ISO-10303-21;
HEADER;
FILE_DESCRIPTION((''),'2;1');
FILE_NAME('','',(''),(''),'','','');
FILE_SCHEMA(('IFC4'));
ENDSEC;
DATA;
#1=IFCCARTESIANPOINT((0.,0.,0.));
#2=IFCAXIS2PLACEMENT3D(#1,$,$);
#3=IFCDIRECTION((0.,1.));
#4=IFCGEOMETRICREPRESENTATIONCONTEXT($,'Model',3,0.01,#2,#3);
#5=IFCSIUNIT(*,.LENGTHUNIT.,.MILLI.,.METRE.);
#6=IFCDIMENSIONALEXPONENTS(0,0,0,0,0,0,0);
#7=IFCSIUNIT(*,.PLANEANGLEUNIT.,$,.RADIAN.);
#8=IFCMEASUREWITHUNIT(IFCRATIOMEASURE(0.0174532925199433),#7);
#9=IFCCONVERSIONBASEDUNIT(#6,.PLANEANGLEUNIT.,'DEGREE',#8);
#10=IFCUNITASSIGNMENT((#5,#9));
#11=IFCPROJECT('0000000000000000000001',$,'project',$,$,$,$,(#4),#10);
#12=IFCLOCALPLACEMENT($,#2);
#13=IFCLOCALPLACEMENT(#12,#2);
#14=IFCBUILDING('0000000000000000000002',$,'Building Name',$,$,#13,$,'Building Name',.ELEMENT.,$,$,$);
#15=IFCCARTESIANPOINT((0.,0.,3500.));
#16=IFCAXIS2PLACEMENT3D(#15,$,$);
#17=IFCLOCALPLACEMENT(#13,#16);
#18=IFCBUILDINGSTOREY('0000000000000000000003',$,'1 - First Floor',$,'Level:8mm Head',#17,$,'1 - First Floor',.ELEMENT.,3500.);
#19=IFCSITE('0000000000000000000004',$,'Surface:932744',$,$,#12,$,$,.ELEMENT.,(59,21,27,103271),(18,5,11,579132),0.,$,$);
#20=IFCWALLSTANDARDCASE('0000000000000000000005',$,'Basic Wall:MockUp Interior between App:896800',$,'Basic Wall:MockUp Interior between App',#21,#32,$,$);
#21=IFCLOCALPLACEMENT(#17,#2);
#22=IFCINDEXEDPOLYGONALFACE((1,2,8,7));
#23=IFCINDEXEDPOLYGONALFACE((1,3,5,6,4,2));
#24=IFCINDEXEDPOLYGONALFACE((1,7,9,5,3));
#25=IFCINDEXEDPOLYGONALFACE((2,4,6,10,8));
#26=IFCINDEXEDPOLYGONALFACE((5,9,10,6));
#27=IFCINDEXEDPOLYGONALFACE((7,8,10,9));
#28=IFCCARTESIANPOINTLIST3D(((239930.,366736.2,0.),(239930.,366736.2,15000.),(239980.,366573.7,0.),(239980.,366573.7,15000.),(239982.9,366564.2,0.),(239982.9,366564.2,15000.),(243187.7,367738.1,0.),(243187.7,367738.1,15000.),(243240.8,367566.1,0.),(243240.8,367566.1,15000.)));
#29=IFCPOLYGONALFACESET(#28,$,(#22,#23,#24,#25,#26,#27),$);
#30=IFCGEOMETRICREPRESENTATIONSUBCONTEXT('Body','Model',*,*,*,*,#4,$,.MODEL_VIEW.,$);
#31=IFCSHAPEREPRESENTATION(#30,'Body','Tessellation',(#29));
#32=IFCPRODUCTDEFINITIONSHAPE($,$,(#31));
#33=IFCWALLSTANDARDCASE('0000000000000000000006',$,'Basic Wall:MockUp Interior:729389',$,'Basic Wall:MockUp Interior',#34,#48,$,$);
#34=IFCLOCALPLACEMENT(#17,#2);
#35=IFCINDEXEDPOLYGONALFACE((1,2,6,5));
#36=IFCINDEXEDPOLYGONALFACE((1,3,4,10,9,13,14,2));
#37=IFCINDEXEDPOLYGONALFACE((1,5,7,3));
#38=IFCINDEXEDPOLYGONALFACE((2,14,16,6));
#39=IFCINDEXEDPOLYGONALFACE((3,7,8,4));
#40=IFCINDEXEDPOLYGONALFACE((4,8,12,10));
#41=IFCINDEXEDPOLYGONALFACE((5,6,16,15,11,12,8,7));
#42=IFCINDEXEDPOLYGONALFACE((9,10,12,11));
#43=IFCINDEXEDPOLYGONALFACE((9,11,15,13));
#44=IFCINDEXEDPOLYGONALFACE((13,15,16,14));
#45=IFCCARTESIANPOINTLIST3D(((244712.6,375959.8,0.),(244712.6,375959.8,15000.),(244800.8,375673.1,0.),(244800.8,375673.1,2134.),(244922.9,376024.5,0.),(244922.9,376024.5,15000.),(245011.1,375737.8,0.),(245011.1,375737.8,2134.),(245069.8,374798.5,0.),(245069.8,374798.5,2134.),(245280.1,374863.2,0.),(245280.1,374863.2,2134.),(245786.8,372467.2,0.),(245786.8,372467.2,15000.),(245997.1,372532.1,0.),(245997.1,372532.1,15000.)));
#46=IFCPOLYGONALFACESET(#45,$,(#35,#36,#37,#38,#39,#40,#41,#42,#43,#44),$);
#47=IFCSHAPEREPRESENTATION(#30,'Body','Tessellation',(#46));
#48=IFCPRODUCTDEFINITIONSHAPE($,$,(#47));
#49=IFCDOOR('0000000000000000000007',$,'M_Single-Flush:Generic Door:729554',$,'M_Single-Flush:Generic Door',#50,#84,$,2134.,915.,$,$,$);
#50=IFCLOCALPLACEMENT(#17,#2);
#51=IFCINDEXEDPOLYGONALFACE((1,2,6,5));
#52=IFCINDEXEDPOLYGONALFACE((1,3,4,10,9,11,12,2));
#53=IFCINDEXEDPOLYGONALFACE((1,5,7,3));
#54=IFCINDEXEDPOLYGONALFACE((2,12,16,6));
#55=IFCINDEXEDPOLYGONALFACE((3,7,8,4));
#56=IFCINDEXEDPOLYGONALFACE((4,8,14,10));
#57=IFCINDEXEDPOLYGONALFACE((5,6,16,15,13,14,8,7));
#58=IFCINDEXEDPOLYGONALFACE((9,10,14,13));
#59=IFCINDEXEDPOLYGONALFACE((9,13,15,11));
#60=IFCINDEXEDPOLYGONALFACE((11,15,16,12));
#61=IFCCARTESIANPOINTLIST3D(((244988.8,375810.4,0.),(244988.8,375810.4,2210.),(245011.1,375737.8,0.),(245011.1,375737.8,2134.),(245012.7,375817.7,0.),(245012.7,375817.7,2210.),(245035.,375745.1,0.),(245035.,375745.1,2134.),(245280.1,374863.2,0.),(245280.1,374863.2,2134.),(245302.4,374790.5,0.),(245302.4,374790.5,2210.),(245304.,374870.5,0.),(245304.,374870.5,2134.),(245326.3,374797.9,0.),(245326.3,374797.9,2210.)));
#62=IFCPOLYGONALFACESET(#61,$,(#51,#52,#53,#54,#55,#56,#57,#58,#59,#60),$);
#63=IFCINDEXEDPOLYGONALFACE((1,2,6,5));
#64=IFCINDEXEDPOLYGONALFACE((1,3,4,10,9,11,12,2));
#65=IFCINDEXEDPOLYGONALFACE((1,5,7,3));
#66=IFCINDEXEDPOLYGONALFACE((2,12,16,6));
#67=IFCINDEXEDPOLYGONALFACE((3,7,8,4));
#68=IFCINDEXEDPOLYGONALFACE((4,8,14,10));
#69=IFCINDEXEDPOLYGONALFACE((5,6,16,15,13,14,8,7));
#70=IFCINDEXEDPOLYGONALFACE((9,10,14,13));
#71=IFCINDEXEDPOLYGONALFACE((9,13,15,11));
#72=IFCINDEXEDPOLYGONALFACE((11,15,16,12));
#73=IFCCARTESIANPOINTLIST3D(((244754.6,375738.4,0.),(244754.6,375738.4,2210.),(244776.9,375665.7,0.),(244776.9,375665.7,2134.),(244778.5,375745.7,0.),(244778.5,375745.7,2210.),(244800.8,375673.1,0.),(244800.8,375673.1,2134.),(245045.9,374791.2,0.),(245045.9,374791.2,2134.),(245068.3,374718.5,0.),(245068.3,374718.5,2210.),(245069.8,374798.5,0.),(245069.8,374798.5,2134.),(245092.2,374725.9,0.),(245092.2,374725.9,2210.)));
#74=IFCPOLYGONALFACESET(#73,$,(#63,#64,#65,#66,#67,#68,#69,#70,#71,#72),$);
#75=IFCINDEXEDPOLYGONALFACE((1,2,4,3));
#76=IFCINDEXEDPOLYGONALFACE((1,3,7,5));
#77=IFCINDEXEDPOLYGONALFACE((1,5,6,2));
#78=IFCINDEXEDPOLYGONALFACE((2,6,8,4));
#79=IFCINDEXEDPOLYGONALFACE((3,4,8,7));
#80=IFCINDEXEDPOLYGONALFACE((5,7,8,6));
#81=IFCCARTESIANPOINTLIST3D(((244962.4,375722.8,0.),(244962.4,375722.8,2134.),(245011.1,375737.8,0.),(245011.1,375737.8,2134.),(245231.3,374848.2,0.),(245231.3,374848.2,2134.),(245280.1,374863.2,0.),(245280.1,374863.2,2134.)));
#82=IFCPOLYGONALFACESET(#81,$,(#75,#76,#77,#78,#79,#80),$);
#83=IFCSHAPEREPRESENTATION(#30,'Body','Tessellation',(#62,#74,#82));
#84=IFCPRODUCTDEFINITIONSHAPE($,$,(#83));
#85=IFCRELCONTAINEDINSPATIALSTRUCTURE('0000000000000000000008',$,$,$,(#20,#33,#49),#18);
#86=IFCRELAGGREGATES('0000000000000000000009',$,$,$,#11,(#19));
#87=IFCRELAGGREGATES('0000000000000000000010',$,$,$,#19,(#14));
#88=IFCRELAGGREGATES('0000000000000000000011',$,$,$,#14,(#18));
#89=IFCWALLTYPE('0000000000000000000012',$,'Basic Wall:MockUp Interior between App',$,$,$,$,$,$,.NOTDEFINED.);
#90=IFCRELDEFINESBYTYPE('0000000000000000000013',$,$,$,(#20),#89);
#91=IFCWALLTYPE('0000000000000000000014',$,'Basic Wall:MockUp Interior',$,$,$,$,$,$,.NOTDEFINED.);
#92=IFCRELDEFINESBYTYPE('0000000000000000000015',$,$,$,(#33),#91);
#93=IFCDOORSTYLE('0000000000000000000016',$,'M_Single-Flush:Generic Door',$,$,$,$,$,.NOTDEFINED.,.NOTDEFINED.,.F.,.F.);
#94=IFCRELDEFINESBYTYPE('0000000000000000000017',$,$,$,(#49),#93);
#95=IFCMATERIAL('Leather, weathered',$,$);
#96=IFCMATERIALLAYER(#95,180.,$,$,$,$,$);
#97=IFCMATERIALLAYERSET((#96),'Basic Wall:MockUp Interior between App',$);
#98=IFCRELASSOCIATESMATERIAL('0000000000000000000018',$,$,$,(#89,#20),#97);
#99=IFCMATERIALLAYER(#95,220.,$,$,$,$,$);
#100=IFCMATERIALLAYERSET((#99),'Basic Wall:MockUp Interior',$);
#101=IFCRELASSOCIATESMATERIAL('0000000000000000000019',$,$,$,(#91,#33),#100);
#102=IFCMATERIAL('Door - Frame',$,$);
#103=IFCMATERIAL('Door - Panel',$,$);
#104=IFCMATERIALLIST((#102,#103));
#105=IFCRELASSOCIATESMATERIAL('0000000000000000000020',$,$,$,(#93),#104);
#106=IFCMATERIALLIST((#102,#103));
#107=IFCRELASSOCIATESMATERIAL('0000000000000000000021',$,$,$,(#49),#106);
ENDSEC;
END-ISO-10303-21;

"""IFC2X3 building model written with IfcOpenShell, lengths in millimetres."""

from ifc_helpers import new_model, entity, si_unit, converted_unit, direction, frame, frame_2d, origin, place, context, subcontext, project, spatial, polyline, rectangle, outline, extrude, source, transform, mapped, material, material_list, layer, layer_set, layer_usage, type_object, type_shapes, element, fill, save


model = new_model("IFC2X3")

# Units and contexts
model_context = context("Model", 3, precision=0.01, world=origin(), true_north=direction((0.0, 1.0)))
body_context = subcontext(model_context, "Body", "Model", "MODEL_VIEW")
ifc_project = project(units=[si_unit("LENGTHUNIT", "METRE", prefix="MILLI"), converted_unit("PLANEANGLEUNIT", "DEGREE", entity("IfcRatioMeasure", 0.0174532925199433), si_unit("PLANEANGLEUNIT", "RADIAN"), dimensions=[0, 0, 0, 0, 0, 0, 0])], contexts=[model_context])

# Site, building, storey
site_placement = place(None, origin())
site = spatial("IfcSite", under=ifc_project, at=site_placement, Name="Surface:932744", CompositionType="ELEMENT", RefLatitude=(59, 21, 27, 103271), RefLongitude=(18, 5, 11, 579132), RefElevation=0.0)
building_placement = place(site_placement, origin())
building = spatial("IfcBuilding", under=site, at=building_placement, Name="Building Name", LongName="Building Name", CompositionType="ELEMENT")
storey_placement = place(building_placement, frame((0.0, 0.0, 3500.0)))
storey = spatial("IfcBuildingStorey", under=building, at=storey_placement, Name="1 - First Floor", ObjectType="Level:8mm Head", LongName="1 - First Floor", CompositionType="ELEMENT", Elevation=3500.0)

# Shared definitions
ifc_material_1 = material(Name="Leather, weathered")
ifc_layer_1 = layer(ifc_material_1, 180.0)
ifc_layer_set_1 = layer_set([ifc_layer_1], Name="Basic Wall:MockUp Interior between App")
wall_type_1 = type_object("IfcWallType", Name="Basic Wall:MockUp Interior between App", PredefinedType="NOTDEFINED", material=ifc_layer_set_1)

# Shared definitions
ifc_material_2 = material(Name="Door - Frame")
ifc_material_3 = material(Name="Door - Panel")

# Wall
ifc_layer_usage_1 = layer_usage(ifc_layer_set_1, "AXIS2", "NEGATIVE", 90.0)
wall_1_placement = place(storey_placement, frame((243214.4, 367652.1, 0.0), z_axis=(0.0, 0.0, 1.0), x_axis=(-0.955818, -0.293958, 0.0)))
element("IfcWallStandardCase", 1, at=wall_1_placement, inside=storey, type_object=wall_type_1, material=ifc_layer_usage_1, Name="Basic Wall:MockUp Interior between App:896800", ObjectType="Basic Wall:MockUp Interior between App", context=body_context, shape_type="SweptSolid", body=[
    extrude(outline(polyline([(3408.5, -90.0), (3408.5, 80.0), (3408.5, 90.0), (0.0, 90.0), (0.2, -90.0), (3408.5, -90.0)])), origin(), (0.0, 0.0, 1.0), 15000.0),
])

# Wall, opening, door
ifc_layer_2 = layer(ifc_material_1, 220.0)
ifc_layer_set_2 = layer_set([ifc_layer_2], Name="Basic Wall:MockUp Interior")
ifc_layer_usage_2 = layer_usage(ifc_layer_set_2, "AXIS2", "NEGATIVE", 110.0)
wall_type_2 = type_object("IfcWallType", Name="Basic Wall:MockUp Interior", PredefinedType="NOTDEFINED", material=ifc_layer_set_2)
wall_2_placement = place(storey_placement, frame((245892.0, 372499.6, 0.0), z_axis=(0.0, 0.0, 1.0), x_axis=(-0.29398, 0.955811, 0.0)))
wall_2 = element("IfcWallStandardCase", 2, at=wall_2_placement, inside=storey, type_object=wall_type_2, material=ifc_layer_usage_2, Name="Basic Wall:MockUp Interior:729389", ObjectType="Basic Wall:MockUp Interior", context=body_context, shape_type="SweptSolid", body=[
    extrude(outline(polyline([(0.3, -110.0), (2034.1, -110.0), (2134.1, -110.0), (3654.1, -110.0), (3654.1, 110.0), (0.0, 110.0), (0.0, 90.0), (0.2, -90.0), (0.3, -110.0)])), origin(), (0.0, 0.0, 1.0), 15000.0),
])
opening_1_placement = place(wall_2_placement, frame((3354.1, 110.0, 0.0)))
opening_1 = element("IfcOpeningElement", 3, at=opening_1_placement, cuts=wall_2, ObjectType="Opening", context=body_context, shape_type="SweptSolid", body=[
    extrude(rectangle(XDim=915.0, YDim=2134.0, at=frame_2d((1067.0, 457.5), x_axis=(0.0, -1.0))), frame((0.0, 0.0, 0.0), z_axis=(0.0, -1.0, 0.0), x_axis=(0.0, 0.0, 1.0)), (0.0, 0.0, 1.0), 220.0),
])
ifc_material_list_1 = material_list([ifc_material_2, ifc_material_3])
ifc_material_list_2 = material_list([ifc_material_2, ifc_material_3])
door_style_1 = type_object("IfcDoorStyle", Name="M_Single-Flush:Generic Door", ConstructionType="NOTDEFINED", OperationType="NOTDEFINED", ParameterTakesPrecedence=False, Sizeable=False, material=ifc_material_list_2)
shared_shape_1 = source(origin(), body_context, "Body", "SweptSolid", [
    extrude(outline(polyline([(-533.5, -1124.0), (533.5, -1124.0), (533.5, 1086.0), (457.5, 1086.0), (457.5, -1048.0), (-457.5, -1048.0), (-457.5, 1086.0), (-533.5, 1086.0), (-533.5, -1124.0)])), frame((457.5, 245.0, 1086.0), z_axis=(0.0, -1.0, 0.0), x_axis=(-1.0, 0.0, 0.0)), (0.0, 0.0, 1.0), 25.0),
    extrude(outline(polyline([(-1124.0, -533.5), (1086.0, -533.5), (1086.0, -457.5), (-1048.0, -457.5), (-1048.0, 457.5), (1086.0, 457.5), (1086.0, 533.5), (-1124.0, 533.5), (-1124.0, -533.5)])), frame((457.5, 0.0, 1086.0), z_axis=(0.0, -1.0, 0.0), x_axis=(0.0, 0.0, -1.0)), (0.0, 0.0, 1.0), 25.0),
    extrude(rectangle(XDim=915.0, YDim=51.0, at=frame_2d((0.0, 0.0), x_axis=(1.0, 0.0))), frame((457.5, 194.5, 0.0)), (0.0, 0.0, 1.0), 2134.0),
])
type_shapes(door_style_1, [shared_shape_1])
door_1_placement = place(opening_1_placement, frame((0.0, 0.0, 0.0), z_axis=(0.0, 0.0, 1.0), x_axis=(-1.0, 0.0, 0.0)))
door_1 = element("IfcDoor", 4, at=door_1_placement, inside=storey, type_object=door_style_1, material=ifc_material_list_1, Name="M_Single-Flush:Generic Door:729554", ObjectType="M_Single-Flush:Generic Door", OverallHeight=2134.0, OverallWidth=915.0, context=body_context, shape_type="MappedRepresentation", body=[
    mapped(shared_shape_1, transform((0.0, 0.0, 0.0), scale=1.0)),
])
fill(opening_1, door_1)

save(model, "model.ifc")
